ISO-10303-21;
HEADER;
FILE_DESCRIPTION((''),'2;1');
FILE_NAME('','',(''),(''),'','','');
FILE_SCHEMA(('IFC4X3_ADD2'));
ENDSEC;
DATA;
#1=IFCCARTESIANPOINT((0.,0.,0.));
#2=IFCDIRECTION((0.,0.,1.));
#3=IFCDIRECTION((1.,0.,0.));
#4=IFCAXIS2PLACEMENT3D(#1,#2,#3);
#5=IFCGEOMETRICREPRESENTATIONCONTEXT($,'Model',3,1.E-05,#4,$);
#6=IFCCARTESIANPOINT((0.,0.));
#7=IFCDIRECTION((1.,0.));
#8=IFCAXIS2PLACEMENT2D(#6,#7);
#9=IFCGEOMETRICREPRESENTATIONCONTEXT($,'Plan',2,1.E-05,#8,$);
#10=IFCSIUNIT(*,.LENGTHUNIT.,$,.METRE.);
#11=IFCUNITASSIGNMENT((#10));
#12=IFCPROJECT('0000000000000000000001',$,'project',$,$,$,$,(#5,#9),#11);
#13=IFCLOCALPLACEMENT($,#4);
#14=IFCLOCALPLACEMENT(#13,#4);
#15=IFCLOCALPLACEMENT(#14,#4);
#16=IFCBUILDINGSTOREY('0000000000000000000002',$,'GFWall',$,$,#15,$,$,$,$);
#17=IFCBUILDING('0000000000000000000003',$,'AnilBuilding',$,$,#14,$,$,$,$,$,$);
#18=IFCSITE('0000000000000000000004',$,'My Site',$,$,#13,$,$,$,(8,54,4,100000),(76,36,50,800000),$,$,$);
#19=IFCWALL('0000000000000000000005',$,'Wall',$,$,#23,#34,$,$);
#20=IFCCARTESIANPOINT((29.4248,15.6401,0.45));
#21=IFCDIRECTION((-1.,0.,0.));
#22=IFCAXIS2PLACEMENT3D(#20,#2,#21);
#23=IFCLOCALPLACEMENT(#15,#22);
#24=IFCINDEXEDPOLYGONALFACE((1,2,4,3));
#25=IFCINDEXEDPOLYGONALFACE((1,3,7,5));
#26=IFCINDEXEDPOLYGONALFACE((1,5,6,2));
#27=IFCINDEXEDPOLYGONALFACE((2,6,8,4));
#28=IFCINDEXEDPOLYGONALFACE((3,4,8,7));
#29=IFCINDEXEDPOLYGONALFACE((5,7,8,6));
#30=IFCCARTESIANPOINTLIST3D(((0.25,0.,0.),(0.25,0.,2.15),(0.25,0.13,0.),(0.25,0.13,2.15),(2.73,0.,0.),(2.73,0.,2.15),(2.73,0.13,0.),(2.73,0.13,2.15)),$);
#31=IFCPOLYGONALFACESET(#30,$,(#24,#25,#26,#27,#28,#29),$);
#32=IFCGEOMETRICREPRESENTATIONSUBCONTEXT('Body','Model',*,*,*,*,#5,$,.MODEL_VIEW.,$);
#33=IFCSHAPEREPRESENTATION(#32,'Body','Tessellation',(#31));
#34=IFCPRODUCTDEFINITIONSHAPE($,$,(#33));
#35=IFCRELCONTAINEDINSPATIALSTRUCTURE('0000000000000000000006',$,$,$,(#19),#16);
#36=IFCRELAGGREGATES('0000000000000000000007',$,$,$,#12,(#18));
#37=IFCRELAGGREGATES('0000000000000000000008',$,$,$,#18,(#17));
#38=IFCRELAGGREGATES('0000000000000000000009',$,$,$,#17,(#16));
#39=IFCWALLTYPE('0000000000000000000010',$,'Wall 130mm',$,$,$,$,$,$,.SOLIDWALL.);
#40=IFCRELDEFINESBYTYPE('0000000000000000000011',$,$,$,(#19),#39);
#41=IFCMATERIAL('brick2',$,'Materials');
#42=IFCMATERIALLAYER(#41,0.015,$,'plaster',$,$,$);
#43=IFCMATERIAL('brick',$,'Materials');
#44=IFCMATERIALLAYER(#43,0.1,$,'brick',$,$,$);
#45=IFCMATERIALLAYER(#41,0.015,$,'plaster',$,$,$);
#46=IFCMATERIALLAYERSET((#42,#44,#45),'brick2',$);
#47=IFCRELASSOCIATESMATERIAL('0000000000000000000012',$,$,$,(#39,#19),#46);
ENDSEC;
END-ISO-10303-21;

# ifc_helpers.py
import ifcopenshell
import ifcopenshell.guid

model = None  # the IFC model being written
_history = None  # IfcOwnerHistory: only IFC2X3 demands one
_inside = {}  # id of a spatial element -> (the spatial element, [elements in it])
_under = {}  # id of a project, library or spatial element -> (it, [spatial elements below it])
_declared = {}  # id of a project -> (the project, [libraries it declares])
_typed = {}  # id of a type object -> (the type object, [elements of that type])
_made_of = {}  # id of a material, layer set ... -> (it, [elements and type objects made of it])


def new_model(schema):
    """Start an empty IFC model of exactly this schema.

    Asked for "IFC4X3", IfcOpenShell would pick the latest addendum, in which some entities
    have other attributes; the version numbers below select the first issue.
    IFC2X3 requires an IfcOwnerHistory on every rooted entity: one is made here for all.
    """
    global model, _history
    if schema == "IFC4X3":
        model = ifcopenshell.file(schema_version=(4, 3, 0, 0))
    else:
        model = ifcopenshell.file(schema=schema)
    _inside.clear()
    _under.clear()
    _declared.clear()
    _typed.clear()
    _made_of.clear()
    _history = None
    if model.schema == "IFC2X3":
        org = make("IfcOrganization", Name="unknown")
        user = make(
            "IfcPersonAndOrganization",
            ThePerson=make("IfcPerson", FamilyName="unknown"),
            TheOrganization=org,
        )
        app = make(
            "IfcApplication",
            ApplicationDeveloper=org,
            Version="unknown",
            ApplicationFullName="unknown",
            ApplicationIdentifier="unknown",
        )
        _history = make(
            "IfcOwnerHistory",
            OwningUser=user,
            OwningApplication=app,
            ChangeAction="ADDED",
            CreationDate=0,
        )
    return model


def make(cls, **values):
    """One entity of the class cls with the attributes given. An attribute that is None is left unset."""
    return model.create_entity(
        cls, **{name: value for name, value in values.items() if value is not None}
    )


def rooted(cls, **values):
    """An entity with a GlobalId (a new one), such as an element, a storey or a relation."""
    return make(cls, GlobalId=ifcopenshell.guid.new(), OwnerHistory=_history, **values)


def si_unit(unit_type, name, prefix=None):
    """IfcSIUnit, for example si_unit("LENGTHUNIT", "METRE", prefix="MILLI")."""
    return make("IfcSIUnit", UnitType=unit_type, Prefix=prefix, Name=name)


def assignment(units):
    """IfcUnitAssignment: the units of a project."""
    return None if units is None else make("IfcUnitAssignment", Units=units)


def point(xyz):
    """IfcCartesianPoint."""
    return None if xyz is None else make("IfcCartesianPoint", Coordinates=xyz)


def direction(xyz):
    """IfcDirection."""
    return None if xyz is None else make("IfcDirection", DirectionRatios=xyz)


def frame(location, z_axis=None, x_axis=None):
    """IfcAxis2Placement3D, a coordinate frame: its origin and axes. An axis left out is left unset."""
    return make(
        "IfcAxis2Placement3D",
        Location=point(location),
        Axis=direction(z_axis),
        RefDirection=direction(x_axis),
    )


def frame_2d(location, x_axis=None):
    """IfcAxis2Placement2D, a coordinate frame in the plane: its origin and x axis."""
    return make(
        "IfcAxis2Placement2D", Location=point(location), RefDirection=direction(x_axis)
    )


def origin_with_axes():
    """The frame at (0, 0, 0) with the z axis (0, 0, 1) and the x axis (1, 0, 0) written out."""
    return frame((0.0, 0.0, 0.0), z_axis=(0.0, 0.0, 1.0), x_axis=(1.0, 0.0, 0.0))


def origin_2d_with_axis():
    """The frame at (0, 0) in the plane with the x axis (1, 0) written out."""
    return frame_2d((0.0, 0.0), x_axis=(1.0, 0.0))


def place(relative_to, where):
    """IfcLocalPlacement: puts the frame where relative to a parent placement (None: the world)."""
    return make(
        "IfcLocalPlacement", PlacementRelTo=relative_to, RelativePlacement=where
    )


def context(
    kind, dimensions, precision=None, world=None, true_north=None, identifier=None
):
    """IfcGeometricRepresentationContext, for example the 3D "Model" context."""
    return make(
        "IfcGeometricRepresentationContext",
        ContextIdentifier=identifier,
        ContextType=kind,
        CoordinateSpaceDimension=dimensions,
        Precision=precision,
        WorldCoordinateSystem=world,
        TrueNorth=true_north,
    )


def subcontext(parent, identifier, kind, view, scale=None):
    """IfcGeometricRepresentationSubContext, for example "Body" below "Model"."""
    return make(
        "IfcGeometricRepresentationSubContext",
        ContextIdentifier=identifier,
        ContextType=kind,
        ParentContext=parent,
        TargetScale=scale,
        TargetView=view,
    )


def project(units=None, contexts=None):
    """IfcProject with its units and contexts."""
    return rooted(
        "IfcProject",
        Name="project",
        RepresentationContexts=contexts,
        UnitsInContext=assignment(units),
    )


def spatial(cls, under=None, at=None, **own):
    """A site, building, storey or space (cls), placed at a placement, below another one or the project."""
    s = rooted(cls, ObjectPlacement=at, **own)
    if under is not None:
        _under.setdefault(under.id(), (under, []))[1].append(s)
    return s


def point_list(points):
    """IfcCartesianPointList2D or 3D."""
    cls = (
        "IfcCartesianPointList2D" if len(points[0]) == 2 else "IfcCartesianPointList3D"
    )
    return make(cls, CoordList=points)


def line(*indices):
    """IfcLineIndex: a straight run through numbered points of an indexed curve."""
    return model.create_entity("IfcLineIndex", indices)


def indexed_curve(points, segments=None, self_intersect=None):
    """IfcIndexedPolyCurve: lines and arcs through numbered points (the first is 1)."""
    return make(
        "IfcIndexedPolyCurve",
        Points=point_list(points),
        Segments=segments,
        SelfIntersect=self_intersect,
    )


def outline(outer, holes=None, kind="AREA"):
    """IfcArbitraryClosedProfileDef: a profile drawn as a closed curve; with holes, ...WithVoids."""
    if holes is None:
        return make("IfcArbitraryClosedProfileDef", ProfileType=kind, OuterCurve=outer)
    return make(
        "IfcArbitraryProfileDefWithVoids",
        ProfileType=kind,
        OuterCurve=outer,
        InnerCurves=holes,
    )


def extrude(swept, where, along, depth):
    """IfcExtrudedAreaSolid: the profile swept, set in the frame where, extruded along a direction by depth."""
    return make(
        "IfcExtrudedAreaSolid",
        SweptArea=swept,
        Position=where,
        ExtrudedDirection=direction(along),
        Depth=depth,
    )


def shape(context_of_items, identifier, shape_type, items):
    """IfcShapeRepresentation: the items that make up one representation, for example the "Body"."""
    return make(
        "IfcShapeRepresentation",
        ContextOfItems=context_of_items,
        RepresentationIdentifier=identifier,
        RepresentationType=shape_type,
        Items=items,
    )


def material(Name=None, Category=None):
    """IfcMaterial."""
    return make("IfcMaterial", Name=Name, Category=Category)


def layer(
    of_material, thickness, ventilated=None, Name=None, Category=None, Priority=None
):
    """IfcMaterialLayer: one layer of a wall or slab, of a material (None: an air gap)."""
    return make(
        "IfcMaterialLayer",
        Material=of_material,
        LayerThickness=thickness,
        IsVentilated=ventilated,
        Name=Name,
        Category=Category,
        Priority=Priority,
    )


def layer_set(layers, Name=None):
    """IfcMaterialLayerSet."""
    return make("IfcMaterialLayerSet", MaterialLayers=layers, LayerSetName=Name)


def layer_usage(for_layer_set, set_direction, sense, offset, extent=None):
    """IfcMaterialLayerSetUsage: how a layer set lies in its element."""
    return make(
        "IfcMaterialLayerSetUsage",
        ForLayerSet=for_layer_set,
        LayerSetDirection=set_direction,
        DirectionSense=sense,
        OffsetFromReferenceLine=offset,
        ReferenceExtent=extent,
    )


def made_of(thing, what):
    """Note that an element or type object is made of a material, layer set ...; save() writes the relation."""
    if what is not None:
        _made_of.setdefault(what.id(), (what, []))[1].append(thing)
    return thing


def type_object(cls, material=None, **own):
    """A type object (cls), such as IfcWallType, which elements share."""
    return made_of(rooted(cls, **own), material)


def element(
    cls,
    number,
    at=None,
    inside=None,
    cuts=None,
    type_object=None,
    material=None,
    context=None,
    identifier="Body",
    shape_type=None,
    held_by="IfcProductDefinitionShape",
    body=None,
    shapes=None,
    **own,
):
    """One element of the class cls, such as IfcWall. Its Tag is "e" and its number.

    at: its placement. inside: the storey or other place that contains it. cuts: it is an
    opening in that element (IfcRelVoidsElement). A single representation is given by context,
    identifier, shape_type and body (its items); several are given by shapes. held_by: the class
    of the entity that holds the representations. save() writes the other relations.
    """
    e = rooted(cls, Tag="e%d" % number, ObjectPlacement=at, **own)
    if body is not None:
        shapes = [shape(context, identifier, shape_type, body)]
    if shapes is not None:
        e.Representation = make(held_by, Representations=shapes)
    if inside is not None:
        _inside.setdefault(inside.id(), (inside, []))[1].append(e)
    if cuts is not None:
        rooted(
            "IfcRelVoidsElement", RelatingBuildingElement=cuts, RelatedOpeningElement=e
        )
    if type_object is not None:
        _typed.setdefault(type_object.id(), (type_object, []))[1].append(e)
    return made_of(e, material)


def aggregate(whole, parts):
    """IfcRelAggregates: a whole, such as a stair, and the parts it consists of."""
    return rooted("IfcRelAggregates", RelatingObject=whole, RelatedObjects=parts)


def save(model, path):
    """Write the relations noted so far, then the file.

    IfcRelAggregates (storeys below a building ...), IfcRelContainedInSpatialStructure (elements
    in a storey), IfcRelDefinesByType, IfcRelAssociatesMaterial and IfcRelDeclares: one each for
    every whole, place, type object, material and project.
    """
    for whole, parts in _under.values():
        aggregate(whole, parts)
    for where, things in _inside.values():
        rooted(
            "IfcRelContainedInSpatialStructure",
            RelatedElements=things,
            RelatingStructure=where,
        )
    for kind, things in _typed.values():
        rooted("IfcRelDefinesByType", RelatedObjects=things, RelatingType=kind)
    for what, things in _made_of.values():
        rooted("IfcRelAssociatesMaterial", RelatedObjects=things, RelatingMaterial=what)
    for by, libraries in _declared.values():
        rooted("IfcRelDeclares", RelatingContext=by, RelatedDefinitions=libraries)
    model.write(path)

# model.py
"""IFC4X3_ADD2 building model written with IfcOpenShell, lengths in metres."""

from ifc_helpers import new_model, si_unit, frame, origin_with_axes, origin_2d_with_axis, place, context, subcontext, project, spatial, line, indexed_curve, outline, extrude, material, layer, layer_set, layer_usage, type_object, element, save


model = new_model("IFC4X3_ADD2")

# Units and contexts
model_context = context("Model", 3, precision=1e-05, world=origin_with_axes())
plan_context = context("Plan", 2, precision=1e-05, world=origin_2d_with_axis())
body_context = subcontext(model_context, "Body", "Model", "MODEL_VIEW")
ifc_project = project(units=[si_unit("LENGTHUNIT", "METRE")], contexts=[model_context, plan_context])

# Site, building, storey
site_placement = place(None, origin_with_axes())
site = spatial("IfcSite", under=ifc_project, at=site_placement, Name="My Site", RefLatitude=(8, 54, 4, 100000), RefLongitude=(76, 36, 50, 800000))
building_placement = place(site_placement, origin_with_axes())
building = spatial("IfcBuilding", under=site, at=building_placement, Name="AnilBuilding")
storey_placement = place(building_placement, origin_with_axes())
storey = spatial("IfcBuildingStorey", under=building, at=storey_placement, Name="GFWall")

# Shared definitions
ifc_material_1 = material(Name="brick2", Category="Materials")
ifc_material_2 = material(Name="brick", Category="Materials")

# Wall
ifc_layer_1 = layer(ifc_material_1, 0.015, Name="plaster")
ifc_layer_2 = layer(ifc_material_2, 0.1, Name="brick")
ifc_layer_3 = layer(ifc_material_1, 0.015, Name="plaster")
ifc_layer_set_1 = layer_set([ifc_layer_1, ifc_layer_2, ifc_layer_3], Name="brick2")
wall_type_1 = type_object("IfcWallType", Name="Wall 130mm", PredefinedType="SOLIDWALL", material=ifc_layer_set_1)
ifc_layer_usage_1 = layer_usage(ifc_layer_set_1, "AXIS2", "POSITIVE", 0.0)
wall_1_placement = place(storey_placement, frame((29.4248, 15.6401, 0.45), z_axis=(0.0, 0.0, 1.0), x_axis=(-1.0, 0.0, 0.0)))
element("IfcWall", 1, at=wall_1_placement, inside=storey, type_object=wall_type_1, material=ifc_layer_usage_1, Name="Wall", context=body_context, shape_type="SweptSolid", body=[
    extrude(outline(indexed_curve([(0.25, 0.0), (0.25, 0.13), (2.73, 0.13), (2.73, 0.0)], segments=[line(1, 2, 3, 4, 1)])), origin_with_axes(), (0.0, 0.0, 1.0), 2.15),
])

save(model, "model.ifc")
